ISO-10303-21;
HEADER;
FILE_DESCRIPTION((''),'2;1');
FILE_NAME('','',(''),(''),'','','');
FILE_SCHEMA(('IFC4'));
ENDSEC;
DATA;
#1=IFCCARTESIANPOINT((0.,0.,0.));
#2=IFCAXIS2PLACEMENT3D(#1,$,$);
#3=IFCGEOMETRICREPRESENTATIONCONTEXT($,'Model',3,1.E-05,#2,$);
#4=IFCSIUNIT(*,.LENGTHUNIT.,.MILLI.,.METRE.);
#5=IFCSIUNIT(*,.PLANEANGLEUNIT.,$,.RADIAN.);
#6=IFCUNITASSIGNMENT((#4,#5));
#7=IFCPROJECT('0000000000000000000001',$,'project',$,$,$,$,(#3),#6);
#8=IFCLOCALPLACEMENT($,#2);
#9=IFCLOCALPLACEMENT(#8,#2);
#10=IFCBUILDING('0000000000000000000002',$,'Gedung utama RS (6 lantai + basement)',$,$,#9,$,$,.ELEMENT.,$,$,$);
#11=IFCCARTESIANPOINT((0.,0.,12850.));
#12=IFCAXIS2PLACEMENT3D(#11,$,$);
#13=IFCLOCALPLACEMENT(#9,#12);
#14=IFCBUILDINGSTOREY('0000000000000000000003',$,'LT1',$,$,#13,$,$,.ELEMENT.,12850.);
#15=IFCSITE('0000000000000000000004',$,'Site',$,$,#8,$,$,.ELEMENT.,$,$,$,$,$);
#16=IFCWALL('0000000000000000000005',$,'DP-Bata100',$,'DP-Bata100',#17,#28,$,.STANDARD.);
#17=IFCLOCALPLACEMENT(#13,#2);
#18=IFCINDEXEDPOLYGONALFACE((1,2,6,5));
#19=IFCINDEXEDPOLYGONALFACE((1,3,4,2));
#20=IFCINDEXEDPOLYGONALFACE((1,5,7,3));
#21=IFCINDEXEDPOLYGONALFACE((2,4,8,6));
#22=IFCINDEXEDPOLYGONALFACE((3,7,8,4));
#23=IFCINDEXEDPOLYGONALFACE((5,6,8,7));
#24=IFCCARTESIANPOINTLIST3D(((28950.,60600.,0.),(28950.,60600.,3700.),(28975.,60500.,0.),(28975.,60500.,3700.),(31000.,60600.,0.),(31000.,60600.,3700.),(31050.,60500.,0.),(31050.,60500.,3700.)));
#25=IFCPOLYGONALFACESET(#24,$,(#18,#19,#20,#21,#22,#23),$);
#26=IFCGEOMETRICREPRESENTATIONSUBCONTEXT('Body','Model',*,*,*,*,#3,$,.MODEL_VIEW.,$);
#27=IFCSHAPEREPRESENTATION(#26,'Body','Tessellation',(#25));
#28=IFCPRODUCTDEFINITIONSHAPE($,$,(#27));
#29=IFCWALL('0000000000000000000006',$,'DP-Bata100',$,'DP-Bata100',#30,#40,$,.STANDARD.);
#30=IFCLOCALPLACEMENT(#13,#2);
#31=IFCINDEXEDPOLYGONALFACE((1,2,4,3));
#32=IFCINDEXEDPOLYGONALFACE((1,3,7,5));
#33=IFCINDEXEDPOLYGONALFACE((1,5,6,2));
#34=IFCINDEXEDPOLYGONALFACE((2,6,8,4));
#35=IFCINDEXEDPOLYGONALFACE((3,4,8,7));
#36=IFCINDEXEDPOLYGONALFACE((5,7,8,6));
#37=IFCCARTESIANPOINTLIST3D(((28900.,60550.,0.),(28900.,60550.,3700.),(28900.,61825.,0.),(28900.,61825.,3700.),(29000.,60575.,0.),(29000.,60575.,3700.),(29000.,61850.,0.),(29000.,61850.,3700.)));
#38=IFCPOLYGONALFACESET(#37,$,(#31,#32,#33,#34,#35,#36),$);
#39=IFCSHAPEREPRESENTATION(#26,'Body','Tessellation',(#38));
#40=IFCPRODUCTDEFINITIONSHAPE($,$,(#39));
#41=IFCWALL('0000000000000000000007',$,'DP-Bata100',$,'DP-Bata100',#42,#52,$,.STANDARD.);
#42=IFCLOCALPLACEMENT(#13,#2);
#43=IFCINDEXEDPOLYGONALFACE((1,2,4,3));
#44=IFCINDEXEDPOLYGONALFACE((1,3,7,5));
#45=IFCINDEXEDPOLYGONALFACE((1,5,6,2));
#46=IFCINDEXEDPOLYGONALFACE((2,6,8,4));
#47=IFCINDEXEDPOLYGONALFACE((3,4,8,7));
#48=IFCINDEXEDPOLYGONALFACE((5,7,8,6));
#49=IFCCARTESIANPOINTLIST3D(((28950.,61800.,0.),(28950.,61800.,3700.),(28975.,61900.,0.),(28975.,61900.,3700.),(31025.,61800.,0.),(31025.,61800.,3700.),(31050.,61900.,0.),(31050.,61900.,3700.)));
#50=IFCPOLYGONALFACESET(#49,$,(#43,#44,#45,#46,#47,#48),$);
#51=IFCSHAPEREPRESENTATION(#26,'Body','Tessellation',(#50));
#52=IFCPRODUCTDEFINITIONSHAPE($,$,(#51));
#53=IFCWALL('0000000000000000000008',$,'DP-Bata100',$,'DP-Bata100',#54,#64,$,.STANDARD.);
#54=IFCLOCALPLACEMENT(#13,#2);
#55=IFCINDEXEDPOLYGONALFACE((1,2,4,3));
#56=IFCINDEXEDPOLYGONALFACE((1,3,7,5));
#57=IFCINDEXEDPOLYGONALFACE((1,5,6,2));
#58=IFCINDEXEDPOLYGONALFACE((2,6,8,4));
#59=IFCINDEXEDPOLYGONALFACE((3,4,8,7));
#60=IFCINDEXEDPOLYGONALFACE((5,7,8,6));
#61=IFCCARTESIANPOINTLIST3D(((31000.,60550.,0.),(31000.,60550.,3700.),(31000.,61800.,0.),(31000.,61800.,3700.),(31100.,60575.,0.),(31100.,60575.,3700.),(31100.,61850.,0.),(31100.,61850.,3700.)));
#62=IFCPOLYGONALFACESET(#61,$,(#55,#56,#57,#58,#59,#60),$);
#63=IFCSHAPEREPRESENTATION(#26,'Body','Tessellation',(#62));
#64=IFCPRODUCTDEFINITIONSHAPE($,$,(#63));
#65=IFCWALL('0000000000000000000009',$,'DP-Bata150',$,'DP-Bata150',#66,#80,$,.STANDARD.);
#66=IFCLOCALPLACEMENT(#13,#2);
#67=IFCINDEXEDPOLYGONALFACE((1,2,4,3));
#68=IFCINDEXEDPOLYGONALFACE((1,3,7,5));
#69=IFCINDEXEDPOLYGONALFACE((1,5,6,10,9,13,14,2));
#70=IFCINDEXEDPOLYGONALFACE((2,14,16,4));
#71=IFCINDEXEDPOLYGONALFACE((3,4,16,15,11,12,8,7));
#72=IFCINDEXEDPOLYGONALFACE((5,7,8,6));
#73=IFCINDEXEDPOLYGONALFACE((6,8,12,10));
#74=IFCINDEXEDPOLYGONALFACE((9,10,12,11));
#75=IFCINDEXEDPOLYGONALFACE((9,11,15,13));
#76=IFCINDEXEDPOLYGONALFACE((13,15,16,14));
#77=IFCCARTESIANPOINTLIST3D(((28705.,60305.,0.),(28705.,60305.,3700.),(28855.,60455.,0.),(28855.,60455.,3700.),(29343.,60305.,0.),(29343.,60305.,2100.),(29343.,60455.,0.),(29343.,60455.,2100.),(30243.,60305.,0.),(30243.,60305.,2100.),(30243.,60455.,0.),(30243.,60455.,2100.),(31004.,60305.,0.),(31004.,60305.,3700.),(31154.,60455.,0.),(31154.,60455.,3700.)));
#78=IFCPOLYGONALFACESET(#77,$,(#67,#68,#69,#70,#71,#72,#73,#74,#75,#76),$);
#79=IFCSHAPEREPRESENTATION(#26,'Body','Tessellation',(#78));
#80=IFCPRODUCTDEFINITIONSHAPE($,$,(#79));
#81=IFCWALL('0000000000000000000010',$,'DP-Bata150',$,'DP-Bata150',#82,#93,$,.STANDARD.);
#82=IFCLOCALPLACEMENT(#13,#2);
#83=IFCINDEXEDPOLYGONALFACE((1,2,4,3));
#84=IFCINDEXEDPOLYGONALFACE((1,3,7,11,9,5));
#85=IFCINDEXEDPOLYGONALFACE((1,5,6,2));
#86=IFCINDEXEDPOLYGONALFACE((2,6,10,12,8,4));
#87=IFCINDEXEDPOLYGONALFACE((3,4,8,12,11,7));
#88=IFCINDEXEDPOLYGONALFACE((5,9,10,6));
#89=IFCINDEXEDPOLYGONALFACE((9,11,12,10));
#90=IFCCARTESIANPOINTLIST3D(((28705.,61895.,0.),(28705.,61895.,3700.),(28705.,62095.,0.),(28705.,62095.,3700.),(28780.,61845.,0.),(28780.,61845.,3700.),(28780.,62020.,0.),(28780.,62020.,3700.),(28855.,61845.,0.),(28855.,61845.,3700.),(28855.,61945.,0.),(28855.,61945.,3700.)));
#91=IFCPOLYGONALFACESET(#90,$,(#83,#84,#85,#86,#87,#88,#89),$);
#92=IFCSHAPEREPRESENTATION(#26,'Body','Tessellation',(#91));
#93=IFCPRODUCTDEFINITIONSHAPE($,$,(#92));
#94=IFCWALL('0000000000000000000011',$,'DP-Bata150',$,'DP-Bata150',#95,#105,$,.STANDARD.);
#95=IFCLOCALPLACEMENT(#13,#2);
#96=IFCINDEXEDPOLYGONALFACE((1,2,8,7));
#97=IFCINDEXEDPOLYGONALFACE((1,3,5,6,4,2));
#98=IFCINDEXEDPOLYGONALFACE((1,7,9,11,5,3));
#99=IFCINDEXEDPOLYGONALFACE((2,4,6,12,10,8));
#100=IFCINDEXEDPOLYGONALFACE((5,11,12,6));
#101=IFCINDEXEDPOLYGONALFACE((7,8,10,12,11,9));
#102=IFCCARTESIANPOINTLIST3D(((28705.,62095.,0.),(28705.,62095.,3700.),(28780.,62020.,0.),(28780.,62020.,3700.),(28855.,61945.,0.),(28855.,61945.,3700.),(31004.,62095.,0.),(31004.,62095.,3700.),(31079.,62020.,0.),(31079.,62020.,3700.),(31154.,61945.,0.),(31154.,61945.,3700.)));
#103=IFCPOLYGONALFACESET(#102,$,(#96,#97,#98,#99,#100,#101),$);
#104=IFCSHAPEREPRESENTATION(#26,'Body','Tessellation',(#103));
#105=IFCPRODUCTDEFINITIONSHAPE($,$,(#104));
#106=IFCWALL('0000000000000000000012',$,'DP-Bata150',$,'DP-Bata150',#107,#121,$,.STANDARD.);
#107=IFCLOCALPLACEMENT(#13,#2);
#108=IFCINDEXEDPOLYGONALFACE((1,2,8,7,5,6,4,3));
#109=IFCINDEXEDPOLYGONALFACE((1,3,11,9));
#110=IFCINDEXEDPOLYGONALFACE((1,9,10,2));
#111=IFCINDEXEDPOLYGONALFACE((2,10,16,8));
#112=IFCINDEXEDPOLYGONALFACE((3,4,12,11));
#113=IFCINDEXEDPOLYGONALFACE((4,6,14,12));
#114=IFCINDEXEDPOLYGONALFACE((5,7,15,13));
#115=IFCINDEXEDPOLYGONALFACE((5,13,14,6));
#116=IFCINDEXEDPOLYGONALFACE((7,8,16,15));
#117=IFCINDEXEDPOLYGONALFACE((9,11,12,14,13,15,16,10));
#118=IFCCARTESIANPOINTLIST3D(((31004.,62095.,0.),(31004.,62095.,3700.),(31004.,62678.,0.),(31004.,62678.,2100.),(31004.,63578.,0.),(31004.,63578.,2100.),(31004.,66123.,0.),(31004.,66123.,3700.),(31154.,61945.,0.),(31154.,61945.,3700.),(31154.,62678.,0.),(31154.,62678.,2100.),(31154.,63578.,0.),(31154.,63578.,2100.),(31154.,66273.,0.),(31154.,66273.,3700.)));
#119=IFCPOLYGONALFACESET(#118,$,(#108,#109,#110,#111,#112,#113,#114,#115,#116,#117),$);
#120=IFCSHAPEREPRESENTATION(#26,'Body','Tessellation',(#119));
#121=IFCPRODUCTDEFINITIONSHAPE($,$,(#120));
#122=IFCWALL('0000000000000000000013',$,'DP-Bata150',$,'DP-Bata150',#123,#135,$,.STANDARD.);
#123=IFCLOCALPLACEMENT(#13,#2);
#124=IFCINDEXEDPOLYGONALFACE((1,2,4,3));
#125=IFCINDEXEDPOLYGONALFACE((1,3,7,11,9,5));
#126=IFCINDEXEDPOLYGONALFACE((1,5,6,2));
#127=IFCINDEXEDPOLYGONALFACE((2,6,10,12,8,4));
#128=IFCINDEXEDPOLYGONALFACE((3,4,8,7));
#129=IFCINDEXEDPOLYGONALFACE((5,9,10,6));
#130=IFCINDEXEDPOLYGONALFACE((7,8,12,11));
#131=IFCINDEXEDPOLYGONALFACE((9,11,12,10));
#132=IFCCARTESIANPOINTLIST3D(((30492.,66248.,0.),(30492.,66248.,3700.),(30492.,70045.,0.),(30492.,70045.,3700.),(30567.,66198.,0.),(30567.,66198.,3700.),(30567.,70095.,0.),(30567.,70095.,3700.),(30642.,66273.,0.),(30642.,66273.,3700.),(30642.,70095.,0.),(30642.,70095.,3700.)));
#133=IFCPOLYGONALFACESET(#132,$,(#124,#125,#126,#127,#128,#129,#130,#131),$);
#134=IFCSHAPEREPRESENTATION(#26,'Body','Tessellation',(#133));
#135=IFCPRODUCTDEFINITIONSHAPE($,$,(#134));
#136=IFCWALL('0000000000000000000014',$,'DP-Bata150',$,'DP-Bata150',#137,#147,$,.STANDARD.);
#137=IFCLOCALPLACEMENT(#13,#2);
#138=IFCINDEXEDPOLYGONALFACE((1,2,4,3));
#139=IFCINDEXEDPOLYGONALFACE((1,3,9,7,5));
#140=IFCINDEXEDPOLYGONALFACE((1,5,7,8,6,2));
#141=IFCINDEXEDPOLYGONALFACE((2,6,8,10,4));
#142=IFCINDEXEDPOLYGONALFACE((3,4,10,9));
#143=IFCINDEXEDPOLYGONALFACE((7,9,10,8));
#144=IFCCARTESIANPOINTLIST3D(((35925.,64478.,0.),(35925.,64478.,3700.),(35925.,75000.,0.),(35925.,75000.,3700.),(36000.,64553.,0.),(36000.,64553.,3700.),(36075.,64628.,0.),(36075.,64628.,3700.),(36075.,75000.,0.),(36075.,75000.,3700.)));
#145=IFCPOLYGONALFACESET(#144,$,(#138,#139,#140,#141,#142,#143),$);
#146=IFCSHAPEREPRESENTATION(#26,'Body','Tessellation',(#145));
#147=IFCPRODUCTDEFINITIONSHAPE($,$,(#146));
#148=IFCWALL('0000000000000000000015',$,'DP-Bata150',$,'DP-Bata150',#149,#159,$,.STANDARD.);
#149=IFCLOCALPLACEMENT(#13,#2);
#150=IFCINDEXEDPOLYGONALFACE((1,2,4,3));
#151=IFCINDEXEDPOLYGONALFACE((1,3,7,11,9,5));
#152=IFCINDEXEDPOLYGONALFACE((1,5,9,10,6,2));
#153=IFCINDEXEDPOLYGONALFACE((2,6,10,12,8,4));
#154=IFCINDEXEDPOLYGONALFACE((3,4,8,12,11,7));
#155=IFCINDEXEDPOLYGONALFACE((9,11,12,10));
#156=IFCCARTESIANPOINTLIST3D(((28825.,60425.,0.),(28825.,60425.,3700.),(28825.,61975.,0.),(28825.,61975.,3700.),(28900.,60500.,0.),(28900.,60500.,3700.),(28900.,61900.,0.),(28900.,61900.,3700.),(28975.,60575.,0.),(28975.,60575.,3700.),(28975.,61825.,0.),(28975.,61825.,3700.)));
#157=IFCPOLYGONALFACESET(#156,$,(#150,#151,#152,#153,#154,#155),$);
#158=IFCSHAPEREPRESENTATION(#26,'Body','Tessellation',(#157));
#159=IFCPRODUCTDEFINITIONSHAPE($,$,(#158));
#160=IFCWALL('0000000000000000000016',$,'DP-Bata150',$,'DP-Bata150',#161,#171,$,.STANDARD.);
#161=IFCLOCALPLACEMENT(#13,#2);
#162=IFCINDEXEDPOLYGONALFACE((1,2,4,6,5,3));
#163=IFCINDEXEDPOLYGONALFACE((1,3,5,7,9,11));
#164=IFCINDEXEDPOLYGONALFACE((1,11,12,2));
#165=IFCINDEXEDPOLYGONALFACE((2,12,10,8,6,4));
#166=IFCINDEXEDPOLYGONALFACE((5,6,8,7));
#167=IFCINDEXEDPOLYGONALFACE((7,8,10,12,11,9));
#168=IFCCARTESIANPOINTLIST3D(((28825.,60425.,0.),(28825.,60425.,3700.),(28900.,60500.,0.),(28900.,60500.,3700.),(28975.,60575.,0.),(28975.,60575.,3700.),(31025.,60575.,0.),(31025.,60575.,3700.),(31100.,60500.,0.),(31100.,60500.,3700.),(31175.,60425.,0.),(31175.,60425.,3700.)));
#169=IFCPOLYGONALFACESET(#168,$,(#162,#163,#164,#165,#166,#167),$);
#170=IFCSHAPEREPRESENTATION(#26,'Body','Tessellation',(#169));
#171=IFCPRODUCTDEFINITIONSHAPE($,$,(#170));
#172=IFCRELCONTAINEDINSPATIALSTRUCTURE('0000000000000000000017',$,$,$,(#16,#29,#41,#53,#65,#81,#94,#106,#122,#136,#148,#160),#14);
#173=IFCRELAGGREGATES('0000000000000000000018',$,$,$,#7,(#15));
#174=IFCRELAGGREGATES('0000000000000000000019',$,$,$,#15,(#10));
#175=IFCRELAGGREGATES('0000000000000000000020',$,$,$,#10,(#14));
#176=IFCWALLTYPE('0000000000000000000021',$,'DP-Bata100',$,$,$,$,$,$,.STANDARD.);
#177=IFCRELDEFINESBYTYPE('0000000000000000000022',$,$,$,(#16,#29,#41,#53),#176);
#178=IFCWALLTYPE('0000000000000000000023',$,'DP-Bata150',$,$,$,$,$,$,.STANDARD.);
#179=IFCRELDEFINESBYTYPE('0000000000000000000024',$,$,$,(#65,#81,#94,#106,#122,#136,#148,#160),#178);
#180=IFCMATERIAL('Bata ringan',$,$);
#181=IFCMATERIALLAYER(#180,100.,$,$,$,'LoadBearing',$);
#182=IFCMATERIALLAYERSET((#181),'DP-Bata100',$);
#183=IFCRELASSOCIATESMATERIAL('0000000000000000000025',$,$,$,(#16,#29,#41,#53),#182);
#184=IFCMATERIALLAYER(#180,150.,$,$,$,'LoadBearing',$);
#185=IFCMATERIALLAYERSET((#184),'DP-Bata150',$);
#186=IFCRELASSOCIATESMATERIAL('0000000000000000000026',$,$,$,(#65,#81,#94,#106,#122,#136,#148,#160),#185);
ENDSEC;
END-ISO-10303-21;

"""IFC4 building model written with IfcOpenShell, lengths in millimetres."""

from ifc_helpers import new_model, si_unit, frame, frame_2d, origin, place, context, subcontext, project, spatial, polyline, rectangle, outline, extrude, material, layer, layer_set, layer_usage, type_object, element, save


model = new_model("IFC4")

# Units and contexts
model_context = context("Model", 3, precision=1e-05, world=origin())
body_context = subcontext(model_context, "Body", "Model", "MODEL_VIEW")
ifc_project = project(units=[si_unit("LENGTHUNIT", "METRE", prefix="MILLI"), si_unit("PLANEANGLEUNIT", "RADIAN")], contexts=[model_context])

# Site, building, storey
site_placement = place(None, origin())
site = spatial("IfcSite", under=ifc_project, at=site_placement, Name="Site", CompositionType="ELEMENT")
building_placement = place(site_placement, origin())
building = spatial("IfcBuilding", under=site, at=building_placement, Name="Gedung utama RS (6 lantai + basement)", CompositionType="ELEMENT")
storey_placement = place(building_placement, frame((0.0, 0.0, 12850.0)))
storey = spatial("IfcBuildingStorey", under=building, at=storey_placement, Name="LT1", CompositionType="ELEMENT", Elevation=12850.0)

# Walls
ifc_material = material(Name="Bata ringan")
ifc_layer_1 = layer(ifc_material, 100.0, Category="LoadBearing")
ifc_layer_set_1 = layer_set([ifc_layer_1], Name="DP-Bata100")
ifc_layer_usage_1 = layer_usage(ifc_layer_set_1, "AXIS2", "NEGATIVE", 50.0)
wall_type_1 = type_object("IfcWallType", Name="DP-Bata100", PredefinedType="STANDARD")
wall_1_placement = place(storey_placement, frame((31050.0, 60550.0, 0.0), z_axis=(0.0, 0.0, 1.0), x_axis=(-1.0, 0.0, 0.0)))
element("IfcWall", 1, at=wall_1_placement, inside=storey, type_object=wall_type_1, material=ifc_layer_usage_1, Name="DP-Bata100", ObjectType="DP-Bata100", PredefinedType="STANDARD", context=body_context, shape_type="SweptSolid", body=[
    extrude(outline(polyline([(50.0, -50.0), (0.0, 50.0), (2075.0, 50.0), (2100.0, -50.0), (50.0, -50.0)])), origin(), (0.0, 0.0, 1.0), 3700.0),
])
wall_2_placement = place(storey_placement, frame((28950.0, 60550.0, 0.0), z_axis=(0.0, 0.0, 1.0), x_axis=(0.0, 1.0, 0.0)))
element("IfcWall", 2, at=wall_2_placement, inside=storey, type_object=wall_type_1, material=ifc_layer_usage_1, Name="DP-Bata100", ObjectType="DP-Bata100", PredefinedType="STANDARD", context=body_context, shape_type="SweptSolid", body=[
    extrude(outline(polyline([(25.0, -50.0), (0.0, 50.0), (1275.0, 50.0), (1300.0, -50.0), (25.0, -50.0)])), origin(), (0.0, 0.0, 1.0), 3700.0),
])
wall_3_placement = place(storey_placement, frame((28950.0, 61850.0, 0.0), z_axis=(0.0, 0.0, 1.0), x_axis=(1.0, 0.0, 0.0)))
element("IfcWall", 3, at=wall_3_placement, inside=storey, type_object=wall_type_1, material=ifc_layer_usage_1, Name="DP-Bata100", ObjectType="DP-Bata100", PredefinedType="STANDARD", context=body_context, shape_type="SweptSolid", body=[
    extrude(outline(polyline([(0.0, -50.0), (25.0, 50.0), (2100.0, 50.0), (2075.0, -50.0), (0.0, -50.0)])), origin(), (0.0, 0.0, 1.0), 3700.0),
])
wall_4_placement = place(storey_placement, frame((31050.0, 61850.0, 0.0), z_axis=(0.0, 0.0, 1.0), x_axis=(0.0, -1.0, 0.0)))
element("IfcWall", 4, at=wall_4_placement, inside=storey, type_object=wall_type_1, material=ifc_layer_usage_1, Name="DP-Bata100", ObjectType="DP-Bata100", PredefinedType="STANDARD", context=body_context, shape_type="SweptSolid", body=[
    extrude(outline(polyline([(50.0, -50.0), (0.0, 50.0), (1275.0, 50.0), (1300.0, -50.0), (50.0, -50.0)])), origin(), (0.0, 0.0, 1.0), 3700.0),
])

# Wall, opening
ifc_layer_2 = layer(ifc_material, 150.0, Category="LoadBearing")
ifc_layer_set_2 = layer_set([ifc_layer_2], Name="DP-Bata150")
ifc_layer_usage_2 = layer_usage(ifc_layer_set_2, "AXIS2", "NEGATIVE", 75.0)
wall_type_2 = type_object("IfcWallType", Name="DP-Bata150", PredefinedType="STANDARD")
wall_5_placement = place(storey_placement, frame((31079.0, 60380.0, 0.0), z_axis=(0.0, 0.0, 1.0), x_axis=(-1.0, 0.0, 0.0)))
wall_5 = element("IfcWall", 5, at=wall_5_placement, inside=storey, type_object=wall_type_2, material=ifc_layer_usage_2, Name="DP-Bata150", ObjectType="DP-Bata150", PredefinedType="STANDARD", context=body_context, shape_type="SweptSolid", body=[
    extrude(outline(polyline([(-75.0, -75.0), (0.0, 0.0), (75.0, 75.0), (2374.0, 75.0), (2299.0, 0.0), (2224.0, -75.0), (-75.0, -75.0)])), origin(), (0.0, 0.0, 1.0), 3700.0),
])
opening_1_placement = place(wall_5_placement, frame((836.0, 0.0, 0.0), z_axis=(0.0, 0.0, 1.0), x_axis=(1.0, 0.0, 0.0)))
element("IfcOpeningElement", 6, at=opening_1_placement, cuts=wall_5, PredefinedType="OPENING", context=body_context, shape_type="SweptSolid", body=[
    extrude(rectangle(XDim=900.0, YDim=170.0, at=frame_2d((450.0, 0.0))), origin(), (0.0, 0.0, 1.0), 2100.0),
])

# Walls
wall_6_placement = place(storey_placement, frame((28780.0, 61845.0, 0.0), z_axis=(0.0, 0.0, 1.0), x_axis=(0.0, 1.0, 0.0)))
element("IfcWall", 7, at=wall_6_placement, inside=storey, type_object=wall_type_2, material=ifc_layer_usage_2, Name="DP-Bata150", ObjectType="DP-Bata150", PredefinedType="STANDARD", context=body_context, shape_type="SweptSolid", body=[
    extrude(outline(polyline([(0.0, -75.0), (0.0, 0.0), (50.0, 75.0), (250.0, 75.0), (175.0, 0.0), (100.0, -75.0), (0.0, -75.0)])), origin(), (0.0, 0.0, 1.0), 3700.0),
])
wall_7_placement = place(storey_placement, frame((28780.0, 62020.0, 0.0), z_axis=(0.0, 0.0, 1.0), x_axis=(1.0, 0.0, 0.0)))
element("IfcWall", 8, at=wall_7_placement, inside=storey, type_object=wall_type_2, material=ifc_layer_usage_2, Name="DP-Bata150", ObjectType="DP-Bata150", PredefinedType="STANDARD", context=body_context, shape_type="SweptSolid", body=[
    extrude(outline(polyline([(75.0, -75.0), (0.0, 0.0), (-75.0, 75.0), (2224.0, 75.0), (2299.0, 0.0), (2374.0, -75.0), (75.0, -75.0)])), origin(), (0.0, 0.0, 1.0), 3700.0),
])

# Wall, opening
wall_8_placement = place(storey_placement, frame((31079.0, 62020.0, 0.0), z_axis=(0.0, 0.0, 1.0), x_axis=(0.0, 1.0, 0.0)))
wall_8 = element("IfcWall", 9, at=wall_8_placement, inside=storey, type_object=wall_type_2, material=ifc_layer_usage_2, Name="DP-Bata150", ObjectType="DP-Bata150", PredefinedType="STANDARD", context=body_context, shape_type="SweptSolid", body=[
    extrude(outline(polyline([(-75.0, -75.0), (0.0, 0.0), (75.0, 75.0), (4103.0, 75.0), (4178.0, 0.0), (4253.0, -75.0), (-75.0, -75.0)])), origin(), (0.0, 0.0, 1.0), 3700.0),
])
opening_2_placement = place(wall_8_placement, frame((658.0, 0.0, 0.0), z_axis=(0.0, 0.0, 1.0), x_axis=(1.0, 0.0, 0.0)))
element("IfcOpeningElement", 10, at=opening_2_placement, cuts=wall_8, PredefinedType="OPENING", context=body_context, shape_type="SweptSolid", body=[
    extrude(rectangle(XDim=900.0, YDim=170.0, at=frame_2d((450.0, 0.0))), origin(), (0.0, 0.0, 1.0), 2100.0),
])

# Walls
wall_9_placement = place(storey_placement, frame((30567.0, 66198.0, 0.0), z_axis=(0.0, 0.0, 1.0), x_axis=(0.0, 1.0, 0.0)))
element("IfcWall", 11, at=wall_9_placement, inside=storey, type_object=wall_type_2, material=ifc_layer_usage_2, Name="DP-Bata150", ObjectType="DP-Bata150", PredefinedType="STANDARD", context=body_context, shape_type="SweptSolid", body=[
    extrude(outline(polyline([(75.0, -75.0), (0.0, 0.0), (50.0, 75.0), (3847.0, 75.0), (3897.0, 0.0), (3897.0, -75.0), (75.0, -75.0)])), origin(), (0.0, 0.0, 1.0), 3700.0),
])
wall_10_placement = place(storey_placement, frame((36000.0, 64553.0, 0.0), z_axis=(0.0, 0.0, 1.0), x_axis=(0.0, 1.0, 0.0)))
element("IfcWall", 12, at=wall_10_placement, inside=storey, type_object=wall_type_2, material=ifc_layer_usage_2, Name="DP-Bata150", ObjectType="DP-Bata150", PredefinedType="STANDARD", context=body_context, shape_type="SweptSolid", body=[
    extrude(outline(polyline([(75.0, -75.0), (0.0, 0.0), (-75.0, 75.0), (10447.0, 75.0), (10447.0, -75.0), (75.0, -75.0)])), origin(), (0.0, 0.0, 1.0), 3700.0),
])
wall_11_placement = place(storey_placement, frame((28900.0, 61900.0, 0.0), z_axis=(0.0, 0.0, 1.0), x_axis=(0.0, -1.0, 0.0)))
element("IfcWall", 13, at=wall_11_placement, inside=storey, type_object=wall_type_2, material=ifc_layer_usage_2, Name="DP-Bata150", ObjectType="DP-Bata150", PredefinedType="STANDARD", context=body_context, shape_type="SweptSolid", body=[
    extrude(outline(polyline([(-75.0, -75.0), (0.0, 0.0), (75.0, 75.0), (1325.0, 75.0), (1400.0, 0.0), (1475.0, -75.0), (-75.0, -75.0)])), origin(), (0.0, 0.0, 1.0), 3700.0),
])
wall_12_placement = place(storey_placement, frame((28900.0, 60500.0, 0.0), z_axis=(0.0, 0.0, 1.0), x_axis=(1.0, 0.0, 0.0)))
element("IfcWall", 14, at=wall_12_placement, inside=storey, type_object=wall_type_2, material=ifc_layer_usage_2, Name="DP-Bata150", ObjectType="DP-Bata150", PredefinedType="STANDARD", context=body_context, shape_type="SweptSolid", body=[
    extrude(outline(polyline([(-75.0, -75.0), (0.0, 0.0), (75.0, 75.0), (2125.0, 75.0), (2200.0, 0.0), (2275.0, -75.0), (-75.0, -75.0)])), origin(), (0.0, 0.0, 1.0), 3700.0),
])

save(model, "model.ifc")
